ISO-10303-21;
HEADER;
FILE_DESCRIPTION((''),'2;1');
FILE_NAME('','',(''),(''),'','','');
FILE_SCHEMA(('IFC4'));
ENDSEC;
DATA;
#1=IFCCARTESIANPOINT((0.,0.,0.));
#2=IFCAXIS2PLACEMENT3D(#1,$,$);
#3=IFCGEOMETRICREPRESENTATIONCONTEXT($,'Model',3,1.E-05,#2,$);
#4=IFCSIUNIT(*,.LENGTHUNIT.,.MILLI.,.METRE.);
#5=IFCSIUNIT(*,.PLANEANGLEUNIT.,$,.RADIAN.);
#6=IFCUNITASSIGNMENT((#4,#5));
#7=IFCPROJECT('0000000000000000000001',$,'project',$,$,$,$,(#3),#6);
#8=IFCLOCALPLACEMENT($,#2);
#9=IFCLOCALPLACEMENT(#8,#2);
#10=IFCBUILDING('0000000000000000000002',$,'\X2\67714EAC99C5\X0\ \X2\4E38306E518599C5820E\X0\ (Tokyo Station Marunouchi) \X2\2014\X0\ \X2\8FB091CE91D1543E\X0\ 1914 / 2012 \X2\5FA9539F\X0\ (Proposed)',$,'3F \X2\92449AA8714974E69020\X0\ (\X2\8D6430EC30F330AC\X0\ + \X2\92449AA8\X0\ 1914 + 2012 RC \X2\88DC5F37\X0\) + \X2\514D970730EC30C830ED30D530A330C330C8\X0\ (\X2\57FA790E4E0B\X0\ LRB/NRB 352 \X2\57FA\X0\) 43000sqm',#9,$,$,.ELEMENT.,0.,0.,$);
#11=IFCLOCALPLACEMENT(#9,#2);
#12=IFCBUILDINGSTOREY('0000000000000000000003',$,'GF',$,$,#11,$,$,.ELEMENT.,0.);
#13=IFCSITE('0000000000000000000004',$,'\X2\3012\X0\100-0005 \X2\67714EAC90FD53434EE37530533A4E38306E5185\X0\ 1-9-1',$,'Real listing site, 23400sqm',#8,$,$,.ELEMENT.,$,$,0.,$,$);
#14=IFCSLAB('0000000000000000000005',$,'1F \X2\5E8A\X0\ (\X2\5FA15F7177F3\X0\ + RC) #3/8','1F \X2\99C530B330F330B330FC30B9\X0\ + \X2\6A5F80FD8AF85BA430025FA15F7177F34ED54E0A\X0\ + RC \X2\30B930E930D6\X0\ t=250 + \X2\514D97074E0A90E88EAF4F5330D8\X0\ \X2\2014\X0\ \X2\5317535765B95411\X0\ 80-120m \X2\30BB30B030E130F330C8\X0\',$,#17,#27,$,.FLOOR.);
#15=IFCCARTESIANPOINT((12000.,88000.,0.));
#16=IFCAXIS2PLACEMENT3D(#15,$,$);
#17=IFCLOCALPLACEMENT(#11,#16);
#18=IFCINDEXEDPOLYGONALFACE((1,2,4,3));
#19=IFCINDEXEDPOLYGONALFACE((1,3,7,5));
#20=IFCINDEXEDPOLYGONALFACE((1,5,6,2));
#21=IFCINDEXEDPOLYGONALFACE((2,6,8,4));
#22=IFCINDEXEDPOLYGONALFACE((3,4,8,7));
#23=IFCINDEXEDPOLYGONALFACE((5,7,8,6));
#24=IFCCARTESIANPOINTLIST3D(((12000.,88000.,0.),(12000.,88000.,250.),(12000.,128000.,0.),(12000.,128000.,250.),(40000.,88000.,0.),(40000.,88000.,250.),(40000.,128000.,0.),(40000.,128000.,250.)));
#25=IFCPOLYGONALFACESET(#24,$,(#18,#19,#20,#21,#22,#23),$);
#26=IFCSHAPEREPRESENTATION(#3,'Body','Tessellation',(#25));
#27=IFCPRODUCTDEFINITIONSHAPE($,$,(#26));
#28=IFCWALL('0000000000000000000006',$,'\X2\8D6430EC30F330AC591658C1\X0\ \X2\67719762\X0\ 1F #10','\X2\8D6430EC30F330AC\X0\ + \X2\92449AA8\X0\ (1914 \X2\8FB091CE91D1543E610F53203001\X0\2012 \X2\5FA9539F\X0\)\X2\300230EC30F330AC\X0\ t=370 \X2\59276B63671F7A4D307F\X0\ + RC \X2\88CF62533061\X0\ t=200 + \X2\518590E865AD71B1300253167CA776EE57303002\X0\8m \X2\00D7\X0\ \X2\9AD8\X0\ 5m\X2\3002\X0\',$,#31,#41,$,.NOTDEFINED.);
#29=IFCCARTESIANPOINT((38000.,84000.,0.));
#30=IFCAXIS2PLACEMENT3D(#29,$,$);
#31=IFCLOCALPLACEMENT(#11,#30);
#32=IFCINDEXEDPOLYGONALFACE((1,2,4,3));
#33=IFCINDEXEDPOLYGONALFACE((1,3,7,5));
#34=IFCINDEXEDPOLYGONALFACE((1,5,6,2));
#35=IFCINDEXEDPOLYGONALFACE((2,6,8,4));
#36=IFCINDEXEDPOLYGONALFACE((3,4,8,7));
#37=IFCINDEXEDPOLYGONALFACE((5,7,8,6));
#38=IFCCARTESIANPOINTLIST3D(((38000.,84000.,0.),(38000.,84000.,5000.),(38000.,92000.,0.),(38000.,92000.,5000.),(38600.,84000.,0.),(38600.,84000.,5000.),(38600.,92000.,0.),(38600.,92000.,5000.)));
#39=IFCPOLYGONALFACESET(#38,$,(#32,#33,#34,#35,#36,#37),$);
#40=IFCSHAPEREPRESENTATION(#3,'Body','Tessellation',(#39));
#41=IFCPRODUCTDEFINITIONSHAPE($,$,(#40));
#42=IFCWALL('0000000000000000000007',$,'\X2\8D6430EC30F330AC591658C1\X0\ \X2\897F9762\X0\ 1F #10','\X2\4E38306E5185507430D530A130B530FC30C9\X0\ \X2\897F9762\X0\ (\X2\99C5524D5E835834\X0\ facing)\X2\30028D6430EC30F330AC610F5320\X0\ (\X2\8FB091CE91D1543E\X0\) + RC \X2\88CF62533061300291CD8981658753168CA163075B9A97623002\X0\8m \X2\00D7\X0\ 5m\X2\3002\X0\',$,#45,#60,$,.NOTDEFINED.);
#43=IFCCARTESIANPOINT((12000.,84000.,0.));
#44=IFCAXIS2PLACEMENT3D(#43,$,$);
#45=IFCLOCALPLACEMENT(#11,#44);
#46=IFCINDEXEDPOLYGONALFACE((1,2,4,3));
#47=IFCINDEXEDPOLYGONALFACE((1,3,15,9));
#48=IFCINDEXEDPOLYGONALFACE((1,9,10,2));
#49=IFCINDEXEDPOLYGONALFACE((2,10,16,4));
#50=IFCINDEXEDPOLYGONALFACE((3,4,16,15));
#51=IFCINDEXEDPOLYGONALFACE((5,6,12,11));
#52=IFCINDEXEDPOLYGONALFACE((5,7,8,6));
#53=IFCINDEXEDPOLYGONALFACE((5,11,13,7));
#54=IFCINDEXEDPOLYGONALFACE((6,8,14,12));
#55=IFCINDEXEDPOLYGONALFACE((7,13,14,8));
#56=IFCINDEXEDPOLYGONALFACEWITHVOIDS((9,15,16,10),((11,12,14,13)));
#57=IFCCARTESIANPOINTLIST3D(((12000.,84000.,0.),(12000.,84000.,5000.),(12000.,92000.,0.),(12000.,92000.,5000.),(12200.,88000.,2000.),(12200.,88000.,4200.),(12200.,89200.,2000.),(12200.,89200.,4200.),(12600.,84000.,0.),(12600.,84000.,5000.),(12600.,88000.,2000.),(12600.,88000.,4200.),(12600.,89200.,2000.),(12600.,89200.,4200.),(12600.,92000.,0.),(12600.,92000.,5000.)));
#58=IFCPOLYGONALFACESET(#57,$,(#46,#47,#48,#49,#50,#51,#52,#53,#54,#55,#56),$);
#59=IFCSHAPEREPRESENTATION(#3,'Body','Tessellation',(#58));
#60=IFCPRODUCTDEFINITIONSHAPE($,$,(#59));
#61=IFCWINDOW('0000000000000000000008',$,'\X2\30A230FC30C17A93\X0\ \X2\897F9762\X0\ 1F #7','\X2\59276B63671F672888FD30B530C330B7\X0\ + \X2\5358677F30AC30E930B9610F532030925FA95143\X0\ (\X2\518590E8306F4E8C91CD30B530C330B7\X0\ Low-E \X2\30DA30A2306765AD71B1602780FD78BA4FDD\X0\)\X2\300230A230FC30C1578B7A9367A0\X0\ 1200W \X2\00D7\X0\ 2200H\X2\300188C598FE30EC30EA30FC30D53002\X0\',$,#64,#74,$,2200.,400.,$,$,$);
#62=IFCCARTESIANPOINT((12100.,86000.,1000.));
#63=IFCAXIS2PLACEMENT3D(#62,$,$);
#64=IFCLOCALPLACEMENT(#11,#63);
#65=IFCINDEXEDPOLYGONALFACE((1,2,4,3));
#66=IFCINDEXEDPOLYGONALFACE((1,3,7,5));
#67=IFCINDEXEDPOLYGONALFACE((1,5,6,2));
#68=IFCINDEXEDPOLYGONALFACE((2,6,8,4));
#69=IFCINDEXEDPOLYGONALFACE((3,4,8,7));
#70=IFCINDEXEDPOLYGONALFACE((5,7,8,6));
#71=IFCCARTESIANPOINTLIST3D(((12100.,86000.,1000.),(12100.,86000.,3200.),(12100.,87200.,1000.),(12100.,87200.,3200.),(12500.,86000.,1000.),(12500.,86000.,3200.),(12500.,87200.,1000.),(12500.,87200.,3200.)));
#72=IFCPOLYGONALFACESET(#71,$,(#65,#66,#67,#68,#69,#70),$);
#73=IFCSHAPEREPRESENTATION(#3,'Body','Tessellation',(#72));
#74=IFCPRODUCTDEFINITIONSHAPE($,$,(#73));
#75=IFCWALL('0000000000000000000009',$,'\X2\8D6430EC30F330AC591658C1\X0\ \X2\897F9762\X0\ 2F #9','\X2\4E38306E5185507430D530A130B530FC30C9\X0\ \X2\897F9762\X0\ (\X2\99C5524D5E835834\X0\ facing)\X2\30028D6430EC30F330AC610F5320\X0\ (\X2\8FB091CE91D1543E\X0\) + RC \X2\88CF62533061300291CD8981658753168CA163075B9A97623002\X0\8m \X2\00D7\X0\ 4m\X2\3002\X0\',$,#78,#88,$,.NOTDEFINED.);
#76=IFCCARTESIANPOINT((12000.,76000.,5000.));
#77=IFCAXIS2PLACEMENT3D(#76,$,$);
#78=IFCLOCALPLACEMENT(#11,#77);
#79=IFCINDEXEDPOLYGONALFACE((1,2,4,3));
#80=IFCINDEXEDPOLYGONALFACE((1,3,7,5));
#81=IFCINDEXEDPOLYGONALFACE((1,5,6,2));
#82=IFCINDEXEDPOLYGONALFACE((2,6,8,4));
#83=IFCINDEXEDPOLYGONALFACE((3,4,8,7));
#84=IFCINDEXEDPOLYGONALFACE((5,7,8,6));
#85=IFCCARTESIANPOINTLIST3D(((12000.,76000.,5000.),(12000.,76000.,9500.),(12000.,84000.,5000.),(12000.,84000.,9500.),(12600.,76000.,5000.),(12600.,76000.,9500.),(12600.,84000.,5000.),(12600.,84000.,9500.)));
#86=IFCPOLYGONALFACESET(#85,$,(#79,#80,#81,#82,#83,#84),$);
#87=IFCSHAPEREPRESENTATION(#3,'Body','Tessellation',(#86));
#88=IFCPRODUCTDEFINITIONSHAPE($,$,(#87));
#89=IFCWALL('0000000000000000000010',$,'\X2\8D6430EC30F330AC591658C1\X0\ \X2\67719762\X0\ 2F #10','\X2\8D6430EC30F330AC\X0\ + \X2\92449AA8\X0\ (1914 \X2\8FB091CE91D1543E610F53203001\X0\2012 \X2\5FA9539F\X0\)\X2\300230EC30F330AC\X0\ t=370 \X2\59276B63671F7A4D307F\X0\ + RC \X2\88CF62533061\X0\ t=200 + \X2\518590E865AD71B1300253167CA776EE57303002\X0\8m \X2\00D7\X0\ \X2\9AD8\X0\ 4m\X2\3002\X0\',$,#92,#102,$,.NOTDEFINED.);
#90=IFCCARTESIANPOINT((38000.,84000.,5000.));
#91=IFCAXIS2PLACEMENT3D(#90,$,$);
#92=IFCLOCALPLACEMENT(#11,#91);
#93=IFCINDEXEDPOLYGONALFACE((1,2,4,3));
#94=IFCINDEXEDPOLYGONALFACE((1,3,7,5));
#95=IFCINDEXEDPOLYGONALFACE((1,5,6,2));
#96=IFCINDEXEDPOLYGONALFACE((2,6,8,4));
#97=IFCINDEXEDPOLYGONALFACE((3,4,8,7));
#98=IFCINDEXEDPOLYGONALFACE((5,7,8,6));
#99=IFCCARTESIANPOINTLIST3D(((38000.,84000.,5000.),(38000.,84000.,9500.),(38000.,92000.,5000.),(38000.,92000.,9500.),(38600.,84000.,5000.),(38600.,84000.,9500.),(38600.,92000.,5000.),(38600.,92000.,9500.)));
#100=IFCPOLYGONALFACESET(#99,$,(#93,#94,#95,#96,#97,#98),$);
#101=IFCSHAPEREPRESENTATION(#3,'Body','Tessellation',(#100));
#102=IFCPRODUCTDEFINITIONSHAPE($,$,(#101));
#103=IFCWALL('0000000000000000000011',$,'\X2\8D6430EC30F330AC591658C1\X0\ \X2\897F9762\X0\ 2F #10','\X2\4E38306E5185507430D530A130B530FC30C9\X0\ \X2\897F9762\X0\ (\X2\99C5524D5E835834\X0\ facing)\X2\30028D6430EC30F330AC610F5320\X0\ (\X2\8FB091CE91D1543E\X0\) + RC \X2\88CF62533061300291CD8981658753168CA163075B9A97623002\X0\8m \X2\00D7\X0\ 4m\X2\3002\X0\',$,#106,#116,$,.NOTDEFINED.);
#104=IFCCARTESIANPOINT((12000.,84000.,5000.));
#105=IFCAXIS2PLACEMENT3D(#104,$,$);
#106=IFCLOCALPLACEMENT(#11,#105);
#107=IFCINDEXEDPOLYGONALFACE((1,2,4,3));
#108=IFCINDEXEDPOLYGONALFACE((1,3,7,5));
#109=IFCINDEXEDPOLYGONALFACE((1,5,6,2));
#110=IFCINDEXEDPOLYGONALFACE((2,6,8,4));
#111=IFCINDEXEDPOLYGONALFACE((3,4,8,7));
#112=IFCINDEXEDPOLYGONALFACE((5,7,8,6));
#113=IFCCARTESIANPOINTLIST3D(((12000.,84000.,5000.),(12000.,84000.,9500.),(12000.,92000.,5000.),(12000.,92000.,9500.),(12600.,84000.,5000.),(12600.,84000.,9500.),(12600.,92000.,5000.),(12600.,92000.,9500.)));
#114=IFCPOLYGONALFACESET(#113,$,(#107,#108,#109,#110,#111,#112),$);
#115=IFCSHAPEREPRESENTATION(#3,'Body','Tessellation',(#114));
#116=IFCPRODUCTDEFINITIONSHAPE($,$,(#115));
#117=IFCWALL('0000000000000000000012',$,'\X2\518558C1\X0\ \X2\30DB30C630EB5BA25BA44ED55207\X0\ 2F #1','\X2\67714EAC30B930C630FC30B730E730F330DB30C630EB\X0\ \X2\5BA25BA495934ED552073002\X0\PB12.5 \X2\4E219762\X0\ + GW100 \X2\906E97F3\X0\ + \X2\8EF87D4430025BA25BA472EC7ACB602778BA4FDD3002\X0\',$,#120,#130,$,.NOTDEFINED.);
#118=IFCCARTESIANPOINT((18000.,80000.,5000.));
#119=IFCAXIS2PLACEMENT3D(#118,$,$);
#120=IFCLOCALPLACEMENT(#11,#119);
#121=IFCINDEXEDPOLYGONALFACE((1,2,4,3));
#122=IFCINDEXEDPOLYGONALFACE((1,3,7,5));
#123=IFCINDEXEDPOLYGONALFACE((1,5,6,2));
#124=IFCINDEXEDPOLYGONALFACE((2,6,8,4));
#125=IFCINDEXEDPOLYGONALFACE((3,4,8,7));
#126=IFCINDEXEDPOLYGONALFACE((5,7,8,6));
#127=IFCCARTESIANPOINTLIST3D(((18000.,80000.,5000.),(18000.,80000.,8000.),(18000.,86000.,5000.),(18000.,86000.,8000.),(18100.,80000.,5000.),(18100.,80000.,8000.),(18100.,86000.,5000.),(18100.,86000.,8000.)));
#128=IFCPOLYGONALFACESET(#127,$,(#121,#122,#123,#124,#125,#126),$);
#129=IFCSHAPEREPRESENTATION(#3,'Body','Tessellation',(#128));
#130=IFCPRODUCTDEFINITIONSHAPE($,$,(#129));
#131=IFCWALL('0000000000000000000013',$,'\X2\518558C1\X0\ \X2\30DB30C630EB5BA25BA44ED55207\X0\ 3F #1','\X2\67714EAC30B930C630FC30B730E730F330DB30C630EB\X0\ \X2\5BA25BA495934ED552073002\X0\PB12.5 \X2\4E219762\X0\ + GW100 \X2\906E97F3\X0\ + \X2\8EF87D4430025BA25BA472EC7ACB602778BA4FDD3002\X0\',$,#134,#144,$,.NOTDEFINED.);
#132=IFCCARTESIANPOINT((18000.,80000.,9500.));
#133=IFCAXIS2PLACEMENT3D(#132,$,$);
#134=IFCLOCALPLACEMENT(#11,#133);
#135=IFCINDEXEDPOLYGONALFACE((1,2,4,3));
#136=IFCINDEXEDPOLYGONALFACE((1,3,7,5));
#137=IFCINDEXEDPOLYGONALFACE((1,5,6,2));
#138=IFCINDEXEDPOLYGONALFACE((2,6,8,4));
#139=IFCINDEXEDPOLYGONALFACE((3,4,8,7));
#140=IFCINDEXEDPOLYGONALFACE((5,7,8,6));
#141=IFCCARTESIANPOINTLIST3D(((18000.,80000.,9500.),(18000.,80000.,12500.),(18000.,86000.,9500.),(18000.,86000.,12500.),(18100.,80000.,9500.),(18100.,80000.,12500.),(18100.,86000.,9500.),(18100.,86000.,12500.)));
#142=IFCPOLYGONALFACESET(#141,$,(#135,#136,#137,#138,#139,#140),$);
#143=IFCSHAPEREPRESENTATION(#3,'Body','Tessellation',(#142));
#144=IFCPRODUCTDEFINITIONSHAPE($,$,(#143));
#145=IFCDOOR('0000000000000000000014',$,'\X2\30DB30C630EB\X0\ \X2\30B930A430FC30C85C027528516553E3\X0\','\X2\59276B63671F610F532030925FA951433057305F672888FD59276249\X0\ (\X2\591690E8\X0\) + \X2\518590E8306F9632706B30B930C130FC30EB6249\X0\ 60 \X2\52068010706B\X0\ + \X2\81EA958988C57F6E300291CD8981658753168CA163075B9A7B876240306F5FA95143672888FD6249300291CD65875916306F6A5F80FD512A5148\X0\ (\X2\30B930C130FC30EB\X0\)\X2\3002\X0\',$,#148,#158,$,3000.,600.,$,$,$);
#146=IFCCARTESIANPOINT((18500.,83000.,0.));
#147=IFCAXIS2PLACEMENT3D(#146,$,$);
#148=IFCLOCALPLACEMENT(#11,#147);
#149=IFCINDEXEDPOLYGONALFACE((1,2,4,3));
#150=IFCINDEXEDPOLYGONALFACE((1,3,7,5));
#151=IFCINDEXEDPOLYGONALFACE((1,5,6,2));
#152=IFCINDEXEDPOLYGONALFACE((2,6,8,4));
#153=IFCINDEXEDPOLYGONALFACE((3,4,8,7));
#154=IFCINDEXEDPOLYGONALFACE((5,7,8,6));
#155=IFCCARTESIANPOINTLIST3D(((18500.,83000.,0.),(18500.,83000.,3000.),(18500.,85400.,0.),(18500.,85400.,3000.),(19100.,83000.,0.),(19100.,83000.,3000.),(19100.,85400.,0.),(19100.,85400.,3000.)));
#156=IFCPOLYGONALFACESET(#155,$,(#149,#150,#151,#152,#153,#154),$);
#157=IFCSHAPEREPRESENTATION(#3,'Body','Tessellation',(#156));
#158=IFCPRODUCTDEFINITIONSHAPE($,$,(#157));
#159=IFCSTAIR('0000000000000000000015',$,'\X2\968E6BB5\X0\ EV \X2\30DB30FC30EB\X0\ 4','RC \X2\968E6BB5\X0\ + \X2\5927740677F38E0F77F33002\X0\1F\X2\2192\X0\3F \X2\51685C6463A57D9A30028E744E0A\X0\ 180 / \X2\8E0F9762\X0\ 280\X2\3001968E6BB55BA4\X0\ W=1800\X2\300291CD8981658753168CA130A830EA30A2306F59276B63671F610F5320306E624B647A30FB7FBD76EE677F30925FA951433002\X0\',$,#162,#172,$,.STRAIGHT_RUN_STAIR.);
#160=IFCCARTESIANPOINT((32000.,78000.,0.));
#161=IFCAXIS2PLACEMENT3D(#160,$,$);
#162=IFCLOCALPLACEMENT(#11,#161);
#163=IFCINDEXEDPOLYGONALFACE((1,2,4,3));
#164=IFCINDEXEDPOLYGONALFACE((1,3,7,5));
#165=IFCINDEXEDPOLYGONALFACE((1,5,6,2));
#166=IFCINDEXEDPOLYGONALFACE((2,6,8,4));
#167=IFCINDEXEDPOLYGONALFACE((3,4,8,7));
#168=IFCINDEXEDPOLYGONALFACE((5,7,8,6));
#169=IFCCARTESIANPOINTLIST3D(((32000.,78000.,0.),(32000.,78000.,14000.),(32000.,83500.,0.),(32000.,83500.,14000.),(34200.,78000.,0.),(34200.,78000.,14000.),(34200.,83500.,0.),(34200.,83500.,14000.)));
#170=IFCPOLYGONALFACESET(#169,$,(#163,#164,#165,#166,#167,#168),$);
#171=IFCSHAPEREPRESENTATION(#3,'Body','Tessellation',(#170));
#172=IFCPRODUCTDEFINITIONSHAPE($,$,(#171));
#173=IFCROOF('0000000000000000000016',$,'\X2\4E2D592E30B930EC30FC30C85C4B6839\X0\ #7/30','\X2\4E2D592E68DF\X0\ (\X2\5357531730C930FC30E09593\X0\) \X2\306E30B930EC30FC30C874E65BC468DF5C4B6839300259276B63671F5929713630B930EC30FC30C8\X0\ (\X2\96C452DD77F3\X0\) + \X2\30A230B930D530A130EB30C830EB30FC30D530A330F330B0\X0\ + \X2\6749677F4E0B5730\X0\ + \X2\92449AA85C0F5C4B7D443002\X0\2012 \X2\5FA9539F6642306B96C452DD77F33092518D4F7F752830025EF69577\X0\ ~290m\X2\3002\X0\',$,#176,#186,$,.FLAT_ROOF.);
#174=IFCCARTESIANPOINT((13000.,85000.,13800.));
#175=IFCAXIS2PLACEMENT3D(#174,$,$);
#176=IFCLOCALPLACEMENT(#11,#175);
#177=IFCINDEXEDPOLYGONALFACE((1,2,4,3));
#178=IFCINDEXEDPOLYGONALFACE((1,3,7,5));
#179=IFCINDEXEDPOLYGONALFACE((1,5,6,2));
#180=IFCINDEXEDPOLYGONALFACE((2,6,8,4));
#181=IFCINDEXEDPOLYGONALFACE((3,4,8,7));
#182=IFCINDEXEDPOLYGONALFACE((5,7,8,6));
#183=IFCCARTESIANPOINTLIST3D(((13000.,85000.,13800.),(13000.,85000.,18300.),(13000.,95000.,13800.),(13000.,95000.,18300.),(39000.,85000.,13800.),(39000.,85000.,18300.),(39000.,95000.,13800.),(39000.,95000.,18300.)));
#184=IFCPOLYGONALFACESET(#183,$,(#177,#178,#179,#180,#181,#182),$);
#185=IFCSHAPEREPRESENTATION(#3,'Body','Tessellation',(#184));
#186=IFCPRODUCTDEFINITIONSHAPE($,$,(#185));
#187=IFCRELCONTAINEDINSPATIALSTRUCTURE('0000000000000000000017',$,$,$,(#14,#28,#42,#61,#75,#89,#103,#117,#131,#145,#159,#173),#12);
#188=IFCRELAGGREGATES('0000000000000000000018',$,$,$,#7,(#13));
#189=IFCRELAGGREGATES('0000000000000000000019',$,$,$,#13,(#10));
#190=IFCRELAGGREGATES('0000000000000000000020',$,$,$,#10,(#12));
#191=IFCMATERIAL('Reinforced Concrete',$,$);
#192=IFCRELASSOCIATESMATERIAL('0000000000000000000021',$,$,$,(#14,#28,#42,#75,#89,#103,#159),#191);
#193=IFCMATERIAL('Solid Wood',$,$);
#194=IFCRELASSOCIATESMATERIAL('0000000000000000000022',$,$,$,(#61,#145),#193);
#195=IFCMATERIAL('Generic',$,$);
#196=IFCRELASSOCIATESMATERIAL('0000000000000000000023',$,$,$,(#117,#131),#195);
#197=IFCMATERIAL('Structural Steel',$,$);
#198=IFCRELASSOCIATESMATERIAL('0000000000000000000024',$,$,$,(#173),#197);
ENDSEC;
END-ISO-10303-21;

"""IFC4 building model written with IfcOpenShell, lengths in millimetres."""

from ifc_helpers import new_model, si_unit, frame, frame_2d, origin, place, context, project, spatial, rectangle, extrude, material, element, fill, save


model = new_model("IFC4")

# Units and contexts
model_context = context("Model", 3, precision=1e-05, world=origin())
ifc_project = project(units=[si_unit("LENGTHUNIT", "METRE", prefix="MILLI"), si_unit("PLANEANGLEUNIT", "RADIAN")], contexts=[model_context])

# Site, building, storey
site_placement = place(None, origin())
site = spatial("IfcSite", under=ifc_project, at=site_placement, Name="〒100-0005 東京都千代田区丸の内 1-9-1", ObjectType="Real listing site, 23400sqm", CompositionType="ELEMENT", RefElevation=0.0)
building_placement = place(site_placement, origin())
building = spatial("IfcBuilding", under=site, at=building_placement, Name="東京駅 丸の内駅舎 (Tokyo Station Marunouchi) — 辰野金吾 1914 / 2012 復原 (Proposed)", ObjectType="3F 鉄骨煉瓦造 (赤レンガ + 鉄骨 1914 + 2012 RC 補強) + 免震レトロフィット (基礎下 LRB/NRB 352 基) 43000sqm", CompositionType="ELEMENT", ElevationOfRefHeight=0.0, ElevationOfTerrain=0.0)
storey_placement = place(building_placement, origin())
storey = spatial("IfcBuildingStorey", under=building, at=storey_placement, Name="GF", CompositionType="ELEMENT", Elevation=0.0)

# Shared definitions
ifc_material_1 = material(Name="Structural Steel")

# Slab
ifc_material_2 = material(Name="Reinforced Concrete")
slab_1_placement = place(storey_placement, frame((12000.0, 88000.0, 0.0)))
element("IfcSlab", 1, at=slab_1_placement, inside=storey, material=ifc_material_2, Name="1F 床 (御影石 + RC) #3/8", Description="1F 駅コンコース + 機能諸室。御影石仕上 + RC スラブ t=250 + 免震上部躯体ヘ — 北南方向 80-120m セグメント", PredefinedType="FLOOR", context=model_context, shape_type="SweptSolid", body=[
    extrude(rectangle(XDim=28000.0, YDim=40000.0, at=frame_2d((14000.0, 20000.0))), frame((12000.0, 88000.0, 0.0)), (0.0, 0.0, 1.0), 250.0),
])

# Wall
wall_1_placement = place(storey_placement, frame((38000.0, 84000.0, 0.0)))
element("IfcWall", 2, at=wall_1_placement, inside=storey, material=ifc_material_2, Name="赤レンガ外壁 東面 1F #10", Description="赤レンガ + 鉄骨 (1914 辰野金吾意匠、2012 復原)。レンガ t=370 大正期積み + RC 裏打ち t=200 + 内部断熱。化粧目地。8m × 高 5m。", PredefinedType="NOTDEFINED", context=model_context, shape_type="SweptSolid", body=[
    extrude(rectangle(XDim=600.0, YDim=8000.0, at=frame_2d((300.0, 4000.0))), frame((38000.0, 84000.0, 0.0)), (0.0, 0.0, 1.0), 5000.0),
])

# Wall, opening, window
wall_2_placement = place(storey_placement, frame((12000.0, 84000.0, 0.0)))
wall_2 = element("IfcWall", 3, at=wall_2_placement, inside=storey, material=ifc_material_2, Name="赤レンガ外壁 西面 1F #10", Description="丸の内側ファサード 西面 (駅前広場 facing)。赤レンガ意匠 (辰野金吾) + RC 裏打ち。重要文化財指定面。8m × 5m。", PredefinedType="NOTDEFINED", context=model_context, shape_type="SweptSolid", body=[
    extrude(rectangle(XDim=600.0, YDim=8000.0, at=frame_2d((300.0, 4000.0))), frame((12000.0, 84000.0, 0.0)), (0.0, 0.0, 1.0), 5000.0),
])
opening_placement = place(storey_placement, frame((12100.0, 86000.0, 1000.0)))
opening = element("IfcOpeningElement", 4, at=opening_placement, cuts=wall_2, PredefinedType="NOTDEFINED", context=model_context, shape_type="SweptSolid", body=[
    extrude(rectangle(XDim=400.0, YDim=1200.0, at=frame_2d((200.0, 600.0))), frame((12100.0, 86000.0, 1000.0)), (0.0, 0.0, 1.0), 2200.0),
])
ifc_material_3 = material(Name="Solid Wood")
window_placement = place(storey_placement, frame((12100.0, 86000.0, 1000.0)))
window = element("IfcWindow", 5, at=window_placement, inside=storey, material=ifc_material_3, Name="アーチ窓 西面 1F #7", Description="大正期木製サッシ + 単板ガラス意匠を復元 (内部は二重サッシ Low-E ペアで断熱性能確保)。アーチ型窓枠 1200W × 2200H、装飾レリーフ。", OverallHeight=2200.0, OverallWidth=400.0, context=model_context, shape_type="SweptSolid", body=[
    extrude(rectangle(XDim=400.0, YDim=1200.0, at=frame_2d((200.0, 600.0))), frame((12100.0, 86000.0, 1000.0)), (0.0, 0.0, 1.0), 2200.0),
])
fill(opening, window)

# Walls
wall_3_placement = place(storey_placement, frame((12000.0, 76000.0, 5000.0)))
element("IfcWall", 6, at=wall_3_placement, inside=storey, material=ifc_material_2, Name="赤レンガ外壁 西面 2F #9", Description="丸の内側ファサード 西面 (駅前広場 facing)。赤レンガ意匠 (辰野金吾) + RC 裏打ち。重要文化財指定面。8m × 4m。", PredefinedType="NOTDEFINED", context=model_context, shape_type="SweptSolid", body=[
    extrude(rectangle(XDim=600.0, YDim=8000.0, at=frame_2d((300.0, 4000.0))), frame((12000.0, 76000.0, 5000.0)), (0.0, 0.0, 1.0), 4500.0),
])
wall_4_placement = place(storey_placement, frame((38000.0, 84000.0, 5000.0)))
element("IfcWall", 7, at=wall_4_placement, inside=storey, material=ifc_material_2, Name="赤レンガ外壁 東面 2F #10", Description="赤レンガ + 鉄骨 (1914 辰野金吾意匠、2012 復原)。レンガ t=370 大正期積み + RC 裏打ち t=200 + 内部断熱。化粧目地。8m × 高 4m。", PredefinedType="NOTDEFINED", context=model_context, shape_type="SweptSolid", body=[
    extrude(rectangle(XDim=600.0, YDim=8000.0, at=frame_2d((300.0, 4000.0))), frame((38000.0, 84000.0, 5000.0)), (0.0, 0.0, 1.0), 4500.0),
])
wall_5_placement = place(storey_placement, frame((12000.0, 84000.0, 5000.0)))
element("IfcWall", 8, at=wall_5_placement, inside=storey, material=ifc_material_2, Name="赤レンガ外壁 西面 2F #10", Description="丸の内側ファサード 西面 (駅前広場 facing)。赤レンガ意匠 (辰野金吾) + RC 裏打ち。重要文化財指定面。8m × 4m。", PredefinedType="NOTDEFINED", context=model_context, shape_type="SweptSolid", body=[
    extrude(rectangle(XDim=600.0, YDim=8000.0, at=frame_2d((300.0, 4000.0))), frame((12000.0, 84000.0, 5000.0)), (0.0, 0.0, 1.0), 4500.0),
])
ifc_material_4 = material(Name="Generic")
wall_6_placement = place(storey_placement, frame((18000.0, 80000.0, 5000.0)))
element("IfcWall", 9, at=wall_6_placement, inside=storey, material=ifc_material_4, Name="内壁 ホテル客室仕切 2F #1", Description="東京ステーションホテル 客室間仕切。PB12.5 両面 + GW100 遮音 + 軸組。客室独立性確保。", PredefinedType="NOTDEFINED", context=model_context, shape_type="SweptSolid", body=[
    extrude(rectangle(XDim=100.0, YDim=6000.0, at=frame_2d((50.0, 3000.0))), frame((18000.0, 80000.0, 5000.0)), (0.0, 0.0, 1.0), 3000.0),
])
wall_7_placement = place(storey_placement, frame((18000.0, 80000.0, 9500.0)))
element("IfcWall", 10, at=wall_7_placement, inside=storey, material=ifc_material_4, Name="内壁 ホテル客室仕切 3F #1", Description="東京ステーションホテル 客室間仕切。PB12.5 両面 + GW100 遮音 + 軸組。客室独立性確保。", PredefinedType="NOTDEFINED", context=model_context, shape_type="SweptSolid", body=[
    extrude(rectangle(XDim=100.0, YDim=6000.0, at=frame_2d((50.0, 3000.0))), frame((18000.0, 80000.0, 9500.0)), (0.0, 0.0, 1.0), 3000.0),
])

# Door
door_placement = place(storey_placement, frame((18500.0, 83000.0, 0.0)))
element("IfcDoor", 11, at=door_placement, inside=storey, material=ifc_material_3, Name="ホテル スイート専用入口", Description="大正期意匠を復元した木製大扉 (外部) + 内部は防火スチール扉 60 分耐火 + 自閉装置。重要文化財指定箇所は復元木製扉。重文外は機能優先 (スチール)。", OverallHeight=3000.0, OverallWidth=600.0, context=model_context, shape_type="SweptSolid", body=[
    extrude(rectangle(XDim=600.0, YDim=2400.0, at=frame_2d((300.0, 1200.0))), frame((18500.0, 83000.0, 0.0)), (0.0, 0.0, 1.0), 3000.0),
])

# Stair
stair_placement = place(storey_placement, frame((32000.0, 78000.0, 0.0)))
element("IfcStair", 12, at=stair_placement, inside=storey, material=ifc_material_2, Name="階段 EV ホール 4", Description="RC 階段 + 大理石踏石。1F→3F 全層接続。蹴上 180 / 踏面 280、階段室 W=1800。重要文化財エリアは大正期意匠の手摺・羽目板を復元。", PredefinedType="STRAIGHT_RUN_STAIR", context=model_context, shape_type="SweptSolid", body=[
    extrude(rectangle(XDim=2200.0, YDim=5500.0, at=frame_2d((1100.0, 2750.0))), frame((32000.0, 78000.0, 0.0)), (0.0, 0.0, 1.0), 14000.0),
])

# Roof
roof_placement = place(storey_placement, frame((13000.0, 85000.0, 13800.0)))
element("IfcRoof", 13, at=roof_placement, inside=storey, material=ifc_material_1, Name="中央スレート屋根 #7/30", Description="中央棟 (南北ドーム間) のスレート瓦寄棟屋根。大正期天然スレート (雄勝石) + アスファルトルーフィング + 杉板下地 + 鉄骨小屋組。2012 復原時に雄勝石を再使用。延長 ~290m。", PredefinedType="FLAT_ROOF", context=model_context, shape_type="SweptSolid", body=[
    extrude(rectangle(XDim=26000.0, YDim=10000.0, at=frame_2d((13000.0, 5000.0))), frame((13000.0, 85000.0, 13800.0)), (0.0, 0.0, 1.0), 4500.0),
])

save(model, "model.ifc")
